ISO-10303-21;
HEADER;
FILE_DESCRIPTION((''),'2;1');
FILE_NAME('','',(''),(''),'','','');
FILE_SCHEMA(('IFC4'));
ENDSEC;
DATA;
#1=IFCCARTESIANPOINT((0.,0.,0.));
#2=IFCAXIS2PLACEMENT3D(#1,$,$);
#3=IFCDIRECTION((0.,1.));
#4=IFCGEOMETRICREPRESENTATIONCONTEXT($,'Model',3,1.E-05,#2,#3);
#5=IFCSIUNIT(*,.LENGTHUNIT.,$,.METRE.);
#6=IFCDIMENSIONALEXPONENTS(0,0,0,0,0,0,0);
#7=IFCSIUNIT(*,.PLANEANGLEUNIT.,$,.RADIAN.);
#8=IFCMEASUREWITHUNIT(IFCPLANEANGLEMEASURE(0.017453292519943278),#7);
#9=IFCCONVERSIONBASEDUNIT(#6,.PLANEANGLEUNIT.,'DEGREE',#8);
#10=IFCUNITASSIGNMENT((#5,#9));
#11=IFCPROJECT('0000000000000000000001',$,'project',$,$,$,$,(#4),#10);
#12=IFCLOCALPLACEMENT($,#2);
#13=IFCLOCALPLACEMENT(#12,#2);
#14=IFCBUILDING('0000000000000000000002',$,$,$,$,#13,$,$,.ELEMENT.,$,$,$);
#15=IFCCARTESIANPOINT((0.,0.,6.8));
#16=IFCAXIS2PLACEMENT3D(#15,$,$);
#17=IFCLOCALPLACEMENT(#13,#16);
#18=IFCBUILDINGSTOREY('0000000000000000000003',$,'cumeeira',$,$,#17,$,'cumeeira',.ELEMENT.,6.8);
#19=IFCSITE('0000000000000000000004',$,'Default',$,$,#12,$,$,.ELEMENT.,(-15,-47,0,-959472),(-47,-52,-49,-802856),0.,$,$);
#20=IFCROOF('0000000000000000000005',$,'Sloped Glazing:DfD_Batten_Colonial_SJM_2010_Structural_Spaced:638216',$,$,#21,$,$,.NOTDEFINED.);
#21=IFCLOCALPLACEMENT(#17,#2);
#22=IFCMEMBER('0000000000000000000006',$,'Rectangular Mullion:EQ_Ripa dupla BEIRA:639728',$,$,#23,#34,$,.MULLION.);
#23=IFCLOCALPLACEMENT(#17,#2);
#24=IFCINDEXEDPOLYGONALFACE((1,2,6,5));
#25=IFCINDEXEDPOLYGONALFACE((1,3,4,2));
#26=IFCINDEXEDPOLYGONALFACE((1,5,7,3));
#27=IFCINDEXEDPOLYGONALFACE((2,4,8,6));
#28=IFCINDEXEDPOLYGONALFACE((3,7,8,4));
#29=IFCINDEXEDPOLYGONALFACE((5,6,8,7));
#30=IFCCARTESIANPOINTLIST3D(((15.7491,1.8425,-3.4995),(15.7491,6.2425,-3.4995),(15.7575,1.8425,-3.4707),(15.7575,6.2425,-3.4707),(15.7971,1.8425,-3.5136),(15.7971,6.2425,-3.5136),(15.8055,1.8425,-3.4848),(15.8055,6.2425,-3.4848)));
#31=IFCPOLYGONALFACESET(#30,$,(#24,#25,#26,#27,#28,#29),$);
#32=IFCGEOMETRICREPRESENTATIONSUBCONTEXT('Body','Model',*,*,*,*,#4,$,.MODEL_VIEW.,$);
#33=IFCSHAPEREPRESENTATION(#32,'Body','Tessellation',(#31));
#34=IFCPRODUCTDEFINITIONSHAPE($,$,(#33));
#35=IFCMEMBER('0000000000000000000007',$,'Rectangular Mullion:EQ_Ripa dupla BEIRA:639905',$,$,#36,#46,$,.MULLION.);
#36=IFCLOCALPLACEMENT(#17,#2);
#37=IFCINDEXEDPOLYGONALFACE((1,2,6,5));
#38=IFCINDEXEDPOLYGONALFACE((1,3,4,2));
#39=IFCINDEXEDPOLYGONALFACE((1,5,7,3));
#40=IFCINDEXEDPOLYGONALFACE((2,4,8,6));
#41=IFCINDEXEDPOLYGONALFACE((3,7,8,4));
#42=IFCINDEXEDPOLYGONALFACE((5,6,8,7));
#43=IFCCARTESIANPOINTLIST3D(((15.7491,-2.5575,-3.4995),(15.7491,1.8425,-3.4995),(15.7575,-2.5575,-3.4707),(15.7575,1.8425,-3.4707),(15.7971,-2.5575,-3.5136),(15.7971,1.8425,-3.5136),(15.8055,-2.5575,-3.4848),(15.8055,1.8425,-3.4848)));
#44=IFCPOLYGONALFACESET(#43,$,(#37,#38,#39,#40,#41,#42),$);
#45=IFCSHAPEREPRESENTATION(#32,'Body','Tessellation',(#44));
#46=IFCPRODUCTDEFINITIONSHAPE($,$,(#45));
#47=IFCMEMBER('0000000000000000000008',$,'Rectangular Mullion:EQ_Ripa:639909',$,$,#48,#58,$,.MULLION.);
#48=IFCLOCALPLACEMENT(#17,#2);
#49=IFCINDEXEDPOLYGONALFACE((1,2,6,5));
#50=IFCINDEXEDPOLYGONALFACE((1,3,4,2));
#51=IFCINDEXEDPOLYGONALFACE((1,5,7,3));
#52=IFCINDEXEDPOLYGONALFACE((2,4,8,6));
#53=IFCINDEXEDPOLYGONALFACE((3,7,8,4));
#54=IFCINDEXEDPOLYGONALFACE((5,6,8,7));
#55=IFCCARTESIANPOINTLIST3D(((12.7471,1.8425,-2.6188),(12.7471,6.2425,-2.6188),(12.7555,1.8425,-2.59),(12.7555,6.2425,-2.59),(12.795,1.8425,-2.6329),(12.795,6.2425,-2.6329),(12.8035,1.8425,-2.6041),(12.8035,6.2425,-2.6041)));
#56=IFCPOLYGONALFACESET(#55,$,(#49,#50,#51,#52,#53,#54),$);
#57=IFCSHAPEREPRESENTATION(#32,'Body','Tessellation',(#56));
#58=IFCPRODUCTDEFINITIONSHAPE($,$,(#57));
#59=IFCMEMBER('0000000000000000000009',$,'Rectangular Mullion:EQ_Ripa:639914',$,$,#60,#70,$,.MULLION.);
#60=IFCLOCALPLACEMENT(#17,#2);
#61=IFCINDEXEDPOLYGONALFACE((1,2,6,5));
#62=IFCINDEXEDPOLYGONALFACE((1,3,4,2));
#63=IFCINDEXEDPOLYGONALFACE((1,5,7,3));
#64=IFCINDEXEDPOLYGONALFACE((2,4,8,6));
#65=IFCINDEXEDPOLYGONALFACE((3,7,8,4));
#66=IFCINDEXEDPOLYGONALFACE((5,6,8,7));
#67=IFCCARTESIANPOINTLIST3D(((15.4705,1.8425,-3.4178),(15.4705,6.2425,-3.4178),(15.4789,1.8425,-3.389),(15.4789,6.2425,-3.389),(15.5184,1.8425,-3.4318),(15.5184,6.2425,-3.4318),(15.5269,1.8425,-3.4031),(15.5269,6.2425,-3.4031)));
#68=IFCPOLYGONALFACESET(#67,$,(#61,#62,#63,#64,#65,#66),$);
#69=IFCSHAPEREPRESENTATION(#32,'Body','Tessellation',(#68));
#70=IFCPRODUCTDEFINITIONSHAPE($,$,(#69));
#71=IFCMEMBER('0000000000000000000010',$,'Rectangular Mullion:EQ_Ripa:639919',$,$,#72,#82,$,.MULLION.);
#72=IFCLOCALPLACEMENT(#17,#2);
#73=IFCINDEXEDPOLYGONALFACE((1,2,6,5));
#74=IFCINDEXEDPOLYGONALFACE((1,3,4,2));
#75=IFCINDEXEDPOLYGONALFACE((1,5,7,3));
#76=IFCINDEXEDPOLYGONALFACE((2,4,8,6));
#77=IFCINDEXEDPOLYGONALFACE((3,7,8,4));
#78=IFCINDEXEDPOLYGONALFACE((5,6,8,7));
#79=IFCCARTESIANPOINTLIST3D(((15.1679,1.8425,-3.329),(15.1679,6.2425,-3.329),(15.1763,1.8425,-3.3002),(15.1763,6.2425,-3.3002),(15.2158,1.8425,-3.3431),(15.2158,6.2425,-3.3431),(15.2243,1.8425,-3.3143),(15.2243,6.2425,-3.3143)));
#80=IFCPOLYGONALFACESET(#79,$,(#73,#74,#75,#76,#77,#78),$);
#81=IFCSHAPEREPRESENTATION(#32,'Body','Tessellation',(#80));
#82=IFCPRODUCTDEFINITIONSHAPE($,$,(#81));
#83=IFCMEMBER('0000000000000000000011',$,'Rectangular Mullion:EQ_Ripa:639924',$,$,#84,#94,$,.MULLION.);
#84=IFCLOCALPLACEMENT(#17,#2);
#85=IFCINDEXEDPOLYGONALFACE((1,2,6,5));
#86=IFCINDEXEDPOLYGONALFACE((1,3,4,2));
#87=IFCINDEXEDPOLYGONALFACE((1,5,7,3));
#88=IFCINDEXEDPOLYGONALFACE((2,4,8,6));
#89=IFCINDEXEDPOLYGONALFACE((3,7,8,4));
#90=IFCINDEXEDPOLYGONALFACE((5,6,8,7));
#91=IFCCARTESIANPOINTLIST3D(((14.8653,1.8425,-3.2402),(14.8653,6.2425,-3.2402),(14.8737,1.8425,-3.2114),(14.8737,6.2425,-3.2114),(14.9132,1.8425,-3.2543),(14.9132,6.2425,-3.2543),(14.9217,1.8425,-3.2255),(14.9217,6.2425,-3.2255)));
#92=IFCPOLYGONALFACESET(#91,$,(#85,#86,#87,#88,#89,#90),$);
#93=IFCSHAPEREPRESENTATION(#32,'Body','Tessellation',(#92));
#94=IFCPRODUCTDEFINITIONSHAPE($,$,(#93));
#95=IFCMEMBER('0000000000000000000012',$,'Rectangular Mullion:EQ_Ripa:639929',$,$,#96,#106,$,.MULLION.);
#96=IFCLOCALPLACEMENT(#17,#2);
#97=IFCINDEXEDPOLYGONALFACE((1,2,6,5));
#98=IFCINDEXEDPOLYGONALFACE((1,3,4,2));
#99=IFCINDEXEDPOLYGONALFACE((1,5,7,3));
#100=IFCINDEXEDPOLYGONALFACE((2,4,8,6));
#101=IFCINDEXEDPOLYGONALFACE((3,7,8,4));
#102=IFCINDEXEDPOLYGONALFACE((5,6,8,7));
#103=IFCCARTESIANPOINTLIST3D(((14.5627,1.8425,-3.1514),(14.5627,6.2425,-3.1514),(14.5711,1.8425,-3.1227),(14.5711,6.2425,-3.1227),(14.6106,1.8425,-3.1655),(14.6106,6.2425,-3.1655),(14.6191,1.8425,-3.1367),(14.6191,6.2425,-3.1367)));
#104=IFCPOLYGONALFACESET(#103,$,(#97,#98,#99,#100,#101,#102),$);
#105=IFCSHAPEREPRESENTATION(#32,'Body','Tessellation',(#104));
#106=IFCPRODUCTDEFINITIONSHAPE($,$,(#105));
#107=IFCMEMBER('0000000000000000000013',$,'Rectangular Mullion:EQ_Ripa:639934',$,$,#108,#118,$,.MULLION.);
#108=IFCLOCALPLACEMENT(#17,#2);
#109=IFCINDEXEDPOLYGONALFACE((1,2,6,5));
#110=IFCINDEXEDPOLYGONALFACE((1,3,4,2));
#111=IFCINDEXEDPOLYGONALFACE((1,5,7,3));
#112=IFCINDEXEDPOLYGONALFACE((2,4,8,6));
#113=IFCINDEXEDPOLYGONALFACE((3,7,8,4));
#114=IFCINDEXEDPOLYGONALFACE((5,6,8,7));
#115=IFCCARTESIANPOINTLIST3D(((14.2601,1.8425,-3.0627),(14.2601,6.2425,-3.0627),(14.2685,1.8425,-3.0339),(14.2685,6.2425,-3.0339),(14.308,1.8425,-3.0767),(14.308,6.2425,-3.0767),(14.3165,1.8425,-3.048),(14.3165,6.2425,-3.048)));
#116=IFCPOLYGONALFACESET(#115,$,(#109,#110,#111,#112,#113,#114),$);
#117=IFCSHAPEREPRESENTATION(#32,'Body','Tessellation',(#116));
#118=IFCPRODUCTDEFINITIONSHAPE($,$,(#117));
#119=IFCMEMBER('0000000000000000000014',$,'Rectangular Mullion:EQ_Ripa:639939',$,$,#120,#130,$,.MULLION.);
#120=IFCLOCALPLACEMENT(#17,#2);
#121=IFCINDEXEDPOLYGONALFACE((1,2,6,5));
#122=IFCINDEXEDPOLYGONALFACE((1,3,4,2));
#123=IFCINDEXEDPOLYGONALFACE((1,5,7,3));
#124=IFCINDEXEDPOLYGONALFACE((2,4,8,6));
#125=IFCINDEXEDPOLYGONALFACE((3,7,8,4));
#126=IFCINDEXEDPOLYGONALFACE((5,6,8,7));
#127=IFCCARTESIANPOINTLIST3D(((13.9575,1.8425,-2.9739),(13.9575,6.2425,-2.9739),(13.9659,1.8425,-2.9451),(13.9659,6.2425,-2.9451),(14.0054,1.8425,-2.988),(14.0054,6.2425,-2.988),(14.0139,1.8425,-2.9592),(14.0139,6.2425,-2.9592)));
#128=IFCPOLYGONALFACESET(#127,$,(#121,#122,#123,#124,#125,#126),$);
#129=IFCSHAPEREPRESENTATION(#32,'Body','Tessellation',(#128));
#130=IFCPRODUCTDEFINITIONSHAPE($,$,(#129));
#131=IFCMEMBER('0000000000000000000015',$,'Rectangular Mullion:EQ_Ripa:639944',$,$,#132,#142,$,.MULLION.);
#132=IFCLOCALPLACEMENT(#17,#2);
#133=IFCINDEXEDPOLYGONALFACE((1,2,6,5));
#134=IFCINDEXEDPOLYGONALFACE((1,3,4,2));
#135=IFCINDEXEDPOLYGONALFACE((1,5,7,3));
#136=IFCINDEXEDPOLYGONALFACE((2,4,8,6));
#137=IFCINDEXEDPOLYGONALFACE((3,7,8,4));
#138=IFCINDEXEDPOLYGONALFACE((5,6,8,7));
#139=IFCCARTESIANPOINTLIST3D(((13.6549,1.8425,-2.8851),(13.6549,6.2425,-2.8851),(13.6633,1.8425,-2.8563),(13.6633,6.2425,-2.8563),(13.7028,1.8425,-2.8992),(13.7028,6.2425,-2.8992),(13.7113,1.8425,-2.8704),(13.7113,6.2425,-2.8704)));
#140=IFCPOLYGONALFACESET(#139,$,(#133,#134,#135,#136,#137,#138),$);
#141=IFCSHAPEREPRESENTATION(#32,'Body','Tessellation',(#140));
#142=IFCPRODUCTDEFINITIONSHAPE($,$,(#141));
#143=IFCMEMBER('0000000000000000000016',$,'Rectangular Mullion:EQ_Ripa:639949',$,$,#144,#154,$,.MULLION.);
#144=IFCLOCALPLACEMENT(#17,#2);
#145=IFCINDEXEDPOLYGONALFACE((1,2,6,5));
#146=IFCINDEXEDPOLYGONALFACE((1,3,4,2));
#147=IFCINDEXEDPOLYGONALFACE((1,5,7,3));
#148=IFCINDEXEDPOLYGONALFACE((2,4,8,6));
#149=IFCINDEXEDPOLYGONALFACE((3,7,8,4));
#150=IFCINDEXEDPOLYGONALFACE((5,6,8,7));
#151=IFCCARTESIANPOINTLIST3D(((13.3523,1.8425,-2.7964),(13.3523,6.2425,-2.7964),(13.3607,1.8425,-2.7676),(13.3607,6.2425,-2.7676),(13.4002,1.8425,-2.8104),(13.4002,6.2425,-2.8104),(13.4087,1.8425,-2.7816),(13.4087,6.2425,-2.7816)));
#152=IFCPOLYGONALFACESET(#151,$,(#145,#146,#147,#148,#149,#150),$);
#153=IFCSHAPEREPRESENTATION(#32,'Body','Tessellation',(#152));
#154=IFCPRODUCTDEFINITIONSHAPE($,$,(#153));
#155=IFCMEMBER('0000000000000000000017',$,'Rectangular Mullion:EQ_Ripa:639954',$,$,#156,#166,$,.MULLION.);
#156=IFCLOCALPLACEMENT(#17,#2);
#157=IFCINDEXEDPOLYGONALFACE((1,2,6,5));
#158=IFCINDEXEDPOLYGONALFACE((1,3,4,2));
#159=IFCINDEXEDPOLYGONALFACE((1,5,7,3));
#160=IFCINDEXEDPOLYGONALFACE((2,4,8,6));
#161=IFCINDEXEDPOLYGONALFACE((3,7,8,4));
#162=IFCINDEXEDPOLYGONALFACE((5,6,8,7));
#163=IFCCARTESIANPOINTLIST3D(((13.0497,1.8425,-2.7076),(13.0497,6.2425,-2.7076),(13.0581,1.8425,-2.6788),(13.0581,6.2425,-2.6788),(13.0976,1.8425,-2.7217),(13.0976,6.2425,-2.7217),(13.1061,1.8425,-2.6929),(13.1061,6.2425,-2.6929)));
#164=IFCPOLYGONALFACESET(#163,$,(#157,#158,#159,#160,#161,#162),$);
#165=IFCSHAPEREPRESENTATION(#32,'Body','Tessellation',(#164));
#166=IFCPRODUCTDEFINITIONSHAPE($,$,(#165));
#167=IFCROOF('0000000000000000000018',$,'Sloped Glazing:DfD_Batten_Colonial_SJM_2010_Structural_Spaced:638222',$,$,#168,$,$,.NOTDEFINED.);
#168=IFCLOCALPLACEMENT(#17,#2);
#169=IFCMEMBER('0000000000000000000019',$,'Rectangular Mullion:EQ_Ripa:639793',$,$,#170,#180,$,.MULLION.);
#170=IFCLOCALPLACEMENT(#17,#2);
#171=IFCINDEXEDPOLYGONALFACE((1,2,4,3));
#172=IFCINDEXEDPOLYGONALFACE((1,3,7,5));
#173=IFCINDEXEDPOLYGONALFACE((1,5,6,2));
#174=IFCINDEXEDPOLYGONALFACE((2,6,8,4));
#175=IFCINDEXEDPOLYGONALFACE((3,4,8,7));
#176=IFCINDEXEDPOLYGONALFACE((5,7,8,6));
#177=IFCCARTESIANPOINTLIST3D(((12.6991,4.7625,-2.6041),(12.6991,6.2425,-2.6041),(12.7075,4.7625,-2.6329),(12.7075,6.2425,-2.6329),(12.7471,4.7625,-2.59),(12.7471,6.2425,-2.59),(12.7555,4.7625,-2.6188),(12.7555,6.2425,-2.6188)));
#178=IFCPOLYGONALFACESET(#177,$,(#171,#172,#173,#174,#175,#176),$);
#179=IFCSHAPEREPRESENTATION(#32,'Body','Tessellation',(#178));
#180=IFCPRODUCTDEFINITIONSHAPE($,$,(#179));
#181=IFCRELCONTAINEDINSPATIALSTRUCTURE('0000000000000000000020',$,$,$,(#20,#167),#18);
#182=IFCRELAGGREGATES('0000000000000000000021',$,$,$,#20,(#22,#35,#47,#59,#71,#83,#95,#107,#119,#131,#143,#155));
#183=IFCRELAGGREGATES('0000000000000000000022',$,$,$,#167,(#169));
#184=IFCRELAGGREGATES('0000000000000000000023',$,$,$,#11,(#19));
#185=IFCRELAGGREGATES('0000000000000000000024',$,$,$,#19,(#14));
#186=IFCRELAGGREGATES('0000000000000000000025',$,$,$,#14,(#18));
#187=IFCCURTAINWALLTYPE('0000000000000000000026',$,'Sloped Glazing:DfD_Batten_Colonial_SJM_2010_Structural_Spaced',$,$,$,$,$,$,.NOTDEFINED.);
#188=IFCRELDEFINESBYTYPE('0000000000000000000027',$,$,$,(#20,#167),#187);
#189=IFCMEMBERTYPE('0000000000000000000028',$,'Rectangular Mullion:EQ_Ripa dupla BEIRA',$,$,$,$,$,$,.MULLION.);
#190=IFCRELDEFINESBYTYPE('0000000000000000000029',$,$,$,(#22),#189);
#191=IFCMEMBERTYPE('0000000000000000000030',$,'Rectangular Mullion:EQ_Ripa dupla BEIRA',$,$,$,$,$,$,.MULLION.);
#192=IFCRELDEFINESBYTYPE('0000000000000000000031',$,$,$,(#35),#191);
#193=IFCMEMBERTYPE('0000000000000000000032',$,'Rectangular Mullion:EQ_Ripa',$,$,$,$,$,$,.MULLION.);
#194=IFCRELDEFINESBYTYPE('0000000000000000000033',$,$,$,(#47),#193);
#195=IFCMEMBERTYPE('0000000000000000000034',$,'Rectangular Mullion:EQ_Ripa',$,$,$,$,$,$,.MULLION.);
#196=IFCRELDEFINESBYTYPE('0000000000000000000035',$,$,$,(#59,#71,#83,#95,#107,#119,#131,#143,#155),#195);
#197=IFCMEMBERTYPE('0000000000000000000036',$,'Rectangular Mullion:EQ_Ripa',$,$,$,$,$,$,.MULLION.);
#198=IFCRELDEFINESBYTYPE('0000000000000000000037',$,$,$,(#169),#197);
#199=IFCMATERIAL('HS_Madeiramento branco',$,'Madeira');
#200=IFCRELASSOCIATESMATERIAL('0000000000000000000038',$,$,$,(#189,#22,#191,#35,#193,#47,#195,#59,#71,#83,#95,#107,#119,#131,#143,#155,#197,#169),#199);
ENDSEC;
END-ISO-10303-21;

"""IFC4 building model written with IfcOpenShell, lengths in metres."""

from ifc_helpers import new_model, entity, si_unit, converted_unit, direction, frame, origin, place, context, subcontext, project, spatial, indexed_curve, outline, extrude, source, transform, mapped, material, type_object, type_shapes, element, aggregate, save


model = new_model("IFC4")

# Units and contexts
model_context = context("Model", 3, precision=1e-05, world=origin(), true_north=direction((0.0, 1.0)))
body_context = subcontext(model_context, "Body", "Model", "MODEL_VIEW")
ifc_project = project(units=[si_unit("LENGTHUNIT", "METRE"), converted_unit("PLANEANGLEUNIT", "DEGREE", entity("IfcPlaneAngleMeasure", 0.017453292519943278), si_unit("PLANEANGLEUNIT", "RADIAN"), dimensions=[0, 0, 0, 0, 0, 0, 0])], contexts=[model_context])

# Site, building, storey
site_placement = place(None, origin())
site = spatial("IfcSite", under=ifc_project, at=site_placement, Name="Default", CompositionType="ELEMENT", RefLatitude=(-15, -47, 0, -959472), RefLongitude=(-47, -52, -49, -802856), RefElevation=0.0)
building_placement = place(site_placement, origin())
building = spatial("IfcBuilding", under=site, at=building_placement, CompositionType="ELEMENT")
storey_placement = place(building_placement, frame((0.0, 0.0, 6.8)))
storey = spatial("IfcBuildingStorey", under=building, at=storey_placement, Name="cumeeira", LongName="cumeeira", CompositionType="ELEMENT", Elevation=6.8)

# Roofs, members
curtain_wall_type = type_object("IfcCurtainWallType", Name="Sloped Glazing:DfD_Batten_Colonial_SJM_2010_Structural_Spaced", PredefinedType="NOTDEFINED")
roof_1_placement = place(storey_placement, frame((0.0, 0.0, -6.8)))
roof_1 = element("IfcRoof", 1, at=roof_1_placement, inside=storey, type_object=curtain_wall_type, Name="Sloped Glazing:DfD_Batten_Colonial_SJM_2010_Structural_Spaced:638216", PredefinedType="NOTDEFINED")
ifc_material = material(Name="HS_Madeiramento branco", Category="Madeira")
member_type_1 = type_object("IfcMemberType", Name="Rectangular Mullion:EQ_Ripa dupla BEIRA", PredefinedType="MULLION", material=ifc_material)
shared_shape_1 = source(origin(), body_context, "Body", "SweptSolid", [
    extrude(outline(indexed_curve([(-0.025, -0.015), (0.025, -0.015), (0.025, 0.015), (-0.025, 0.015), (-0.025, -0.015)], self_intersect=False)), frame((-0.025, 0.0, -4.4), z_axis=(0.0, 0.0, 1.0), x_axis=(-1.0, 0.0, 0.0)), (0.0, 0.0, 1.0), 4.4),
])
type_shapes(member_type_1, [shared_shape_1])
member_1_placement = place(roof_1_placement, frame((15.8013, 6.2425, 3.3008), z_axis=(0.0, 1.0, 0.0), x_axis=(0.95956, 0.0, -0.281504)))
member_1 = element("IfcMember", 2, at=member_1_placement, type_object=member_type_1, material=ifc_material, Name="Rectangular Mullion:EQ_Ripa dupla BEIRA:639728", PredefinedType="MULLION", context=body_context, shape_type="MappedRepresentation", body=[
    mapped(shared_shape_1, transform((0.0, 0.0, 0.0), scale=1.0)),
])
member_type_2 = type_object("IfcMemberType", Name="Rectangular Mullion:EQ_Ripa dupla BEIRA", PredefinedType="MULLION", material=ifc_material)
shared_shape_2 = source(origin(), body_context, "Body", "SweptSolid", [
    extrude(outline(indexed_curve([(-0.025, -0.015), (0.025, -0.015), (0.025, 0.015), (-0.025, 0.015), (-0.025, -0.015)], self_intersect=False)), frame((-0.025, 0.0, -4.4), z_axis=(0.0, 0.0, 1.0), x_axis=(-1.0, 0.0, 0.0)), (0.0, 0.0, 1.0), 4.4),
])
type_shapes(member_type_2, [shared_shape_2])
member_2_placement = place(roof_1_placement, frame((15.8013, 1.8425, 3.3008), z_axis=(0.0, 1.0, 0.0), x_axis=(0.95956, 0.0, -0.281504)))
member_2 = element("IfcMember", 3, at=member_2_placement, type_object=member_type_2, material=ifc_material, Name="Rectangular Mullion:EQ_Ripa dupla BEIRA:639905", PredefinedType="MULLION", context=body_context, shape_type="MappedRepresentation", body=[
    mapped(shared_shape_2, transform((0.0, 0.0, 0.0), scale=1.0)),
])
member_type_3 = type_object("IfcMemberType", Name="Rectangular Mullion:EQ_Ripa", PredefinedType="MULLION", material=ifc_material)
shared_shape_3 = source(origin(), body_context, "Body", "SweptSolid", [
    extrude(outline(indexed_curve([(-0.025, -0.015), (0.025, -0.015), (0.025, 0.015), (-0.025, 0.015), (-0.025, -0.015)], self_intersect=False)), frame((-0.025, 0.0, -4.4), z_axis=(0.0, 0.0, 1.0), x_axis=(-1.0, 0.0, 0.0)), (0.0, 0.0, 1.0), 4.4),
])
type_shapes(member_type_3, [shared_shape_3])
member_3_placement = place(roof_1_placement, frame((12.7513, 1.8425, 4.1956), z_axis=(0.0, -1.0, 0.0), x_axis=(-0.95956, 0.0, 0.281504)))
member_3 = element("IfcMember", 4, at=member_3_placement, type_object=member_type_3, material=ifc_material, Name="Rectangular Mullion:EQ_Ripa:639909", PredefinedType="MULLION", context=body_context, shape_type="MappedRepresentation", body=[
    mapped(shared_shape_3, transform((0.0, 0.0, 0.0), scale=1.0)),
])
member_type_4 = type_object("IfcMemberType", Name="Rectangular Mullion:EQ_Ripa", PredefinedType="MULLION", material=ifc_material)
shared_shape_4 = source(origin(), body_context, "Body", "SweptSolid", [
    extrude(outline(indexed_curve([(-0.025, -0.015), (0.025, -0.015), (0.025, 0.015), (-0.025, 0.015), (-0.025, -0.015)], self_intersect=False)), frame((0.0, 0.0, -4.4), z_axis=(0.0, 0.0, 1.0), x_axis=(-1.0, 0.0, 0.0)), (0.0, 0.0, 1.0), 4.4),
])
type_shapes(member_type_4, [shared_shape_4])
member_4_placement = place(roof_1_placement, frame((15.4987, 1.8425, 3.3896), z_axis=(0.0, -1.0, 0.0), x_axis=(-0.95956, 0.0, 0.281504)))
member_4 = element("IfcMember", 5, at=member_4_placement, type_object=member_type_4, material=ifc_material, Name="Rectangular Mullion:EQ_Ripa:639914", PredefinedType="MULLION", context=body_context, shape_type="MappedRepresentation", body=[
    mapped(shared_shape_4, transform((0.0, 0.0, 0.0), scale=1.0)),
])
member_5_placement = place(roof_1_placement, frame((15.1961, 1.8425, 3.4784), z_axis=(0.0, -1.0, 0.0), x_axis=(-0.95956, 0.0, 0.281504)))
member_5 = element("IfcMember", 6, at=member_5_placement, type_object=member_type_4, material=ifc_material, Name="Rectangular Mullion:EQ_Ripa:639919", PredefinedType="MULLION", context=body_context, shape_type="MappedRepresentation", body=[
    mapped(shared_shape_4, transform((0.0, 0.0, 0.0), scale=1.0)),
])
member_6_placement = place(roof_1_placement, frame((14.8935, 1.8425, 3.5671), z_axis=(0.0, -1.0, 0.0), x_axis=(-0.95956, 0.0, 0.281504)))
member_6 = element("IfcMember", 7, at=member_6_placement, type_object=member_type_4, material=ifc_material, Name="Rectangular Mullion:EQ_Ripa:639924", PredefinedType="MULLION", context=body_context, shape_type="MappedRepresentation", body=[
    mapped(shared_shape_4, transform((0.0, 0.0, 0.0), scale=1.0)),
])
member_7_placement = place(roof_1_placement, frame((14.5909, 1.8425, 3.6559), z_axis=(0.0, -1.0, 0.0), x_axis=(-0.95956, 0.0, 0.281504)))
member_7 = element("IfcMember", 8, at=member_7_placement, type_object=member_type_4, material=ifc_material, Name="Rectangular Mullion:EQ_Ripa:639929", PredefinedType="MULLION", context=body_context, shape_type="MappedRepresentation", body=[
    mapped(shared_shape_4, transform((0.0, 0.0, 0.0), scale=1.0)),
])
member_8_placement = place(roof_1_placement, frame((14.2883, 1.8425, 3.7447), z_axis=(0.0, -1.0, 0.0), x_axis=(-0.95956, 0.0, 0.281504)))
member_8 = element("IfcMember", 9, at=member_8_placement, type_object=member_type_4, material=ifc_material, Name="Rectangular Mullion:EQ_Ripa:639934", PredefinedType="MULLION", context=body_context, shape_type="MappedRepresentation", body=[
    mapped(shared_shape_4, transform((0.0, 0.0, 0.0), scale=1.0)),
])
member_9_placement = place(roof_1_placement, frame((13.9857, 1.8425, 3.8335), z_axis=(0.0, -1.0, 0.0), x_axis=(-0.95956, 0.0, 0.281504)))
member_9 = element("IfcMember", 10, at=member_9_placement, type_object=member_type_4, material=ifc_material, Name="Rectangular Mullion:EQ_Ripa:639939", PredefinedType="MULLION", context=body_context, shape_type="MappedRepresentation", body=[
    mapped(shared_shape_4, transform((0.0, 0.0, 0.0), scale=1.0)),
])
member_10_placement = place(roof_1_placement, frame((13.6831, 1.8425, 3.9222), z_axis=(0.0, -1.0, 0.0), x_axis=(-0.95956, 0.0, 0.281504)))
member_10 = element("IfcMember", 11, at=member_10_placement, type_object=member_type_4, material=ifc_material, Name="Rectangular Mullion:EQ_Ripa:639944", PredefinedType="MULLION", context=body_context, shape_type="MappedRepresentation", body=[
    mapped(shared_shape_4, transform((0.0, 0.0, 0.0), scale=1.0)),
])
member_11_placement = place(roof_1_placement, frame((13.3805, 1.8425, 4.011), z_axis=(0.0, -1.0, 0.0), x_axis=(-0.95956, 0.0, 0.281504)))
member_11 = element("IfcMember", 12, at=member_11_placement, type_object=member_type_4, material=ifc_material, Name="Rectangular Mullion:EQ_Ripa:639949", PredefinedType="MULLION", context=body_context, shape_type="MappedRepresentation", body=[
    mapped(shared_shape_4, transform((0.0, 0.0, 0.0), scale=1.0)),
])
member_12_placement = place(roof_1_placement, frame((13.0779, 1.8425, 4.0998), z_axis=(0.0, -1.0, 0.0), x_axis=(-0.95956, 0.0, 0.281504)))
member_12 = element("IfcMember", 13, at=member_12_placement, type_object=member_type_4, material=ifc_material, Name="Rectangular Mullion:EQ_Ripa:639954", PredefinedType="MULLION", context=body_context, shape_type="MappedRepresentation", body=[
    mapped(shared_shape_4, transform((0.0, 0.0, 0.0), scale=1.0)),
])
aggregate(roof_1, [member_1, member_2, member_3, member_4, member_5, member_6, member_7, member_8, member_9, member_10, member_11, member_12])
roof_2_placement = place(storey_placement, frame((0.0, 0.0, -6.8)))
roof_2 = element("IfcRoof", 14, at=roof_2_placement, inside=storey, type_object=curtain_wall_type, Name="Sloped Glazing:DfD_Batten_Colonial_SJM_2010_Structural_Spaced:638222", PredefinedType="NOTDEFINED")
member_type_5 = type_object("IfcMemberType", Name="Rectangular Mullion:EQ_Ripa", PredefinedType="MULLION", material=ifc_material)
shared_shape_5 = source(origin(), body_context, "Body", "SweptSolid", [
    extrude(outline(indexed_curve([(-0.025, -0.015), (0.025, -0.015), (0.025, 0.015), (-0.025, 0.015), (-0.025, -0.015)], self_intersect=False)), frame((-0.025, 0.0, -1.48), z_axis=(0.0, 0.0, 1.0), x_axis=(-1.0, 0.0, 0.0)), (0.0, 0.0, 1.0), 1.48),
])
type_shapes(member_type_5, [shared_shape_5])
member_13_placement = place(roof_2_placement, frame((12.7513, 6.2425, 4.1956), z_axis=(0.0, 1.0, 0.0), x_axis=(0.95956, 0.0, 0.281504)))
member_13 = element("IfcMember", 15, at=member_13_placement, type_object=member_type_5, material=ifc_material, Name="Rectangular Mullion:EQ_Ripa:639793", PredefinedType="MULLION", context=body_context, shape_type="MappedRepresentation", body=[
    mapped(shared_shape_5, transform((0.0, 0.0, 0.0), scale=1.0)),
])
aggregate(roof_2, [member_13])

save(model, "model.ifc")
